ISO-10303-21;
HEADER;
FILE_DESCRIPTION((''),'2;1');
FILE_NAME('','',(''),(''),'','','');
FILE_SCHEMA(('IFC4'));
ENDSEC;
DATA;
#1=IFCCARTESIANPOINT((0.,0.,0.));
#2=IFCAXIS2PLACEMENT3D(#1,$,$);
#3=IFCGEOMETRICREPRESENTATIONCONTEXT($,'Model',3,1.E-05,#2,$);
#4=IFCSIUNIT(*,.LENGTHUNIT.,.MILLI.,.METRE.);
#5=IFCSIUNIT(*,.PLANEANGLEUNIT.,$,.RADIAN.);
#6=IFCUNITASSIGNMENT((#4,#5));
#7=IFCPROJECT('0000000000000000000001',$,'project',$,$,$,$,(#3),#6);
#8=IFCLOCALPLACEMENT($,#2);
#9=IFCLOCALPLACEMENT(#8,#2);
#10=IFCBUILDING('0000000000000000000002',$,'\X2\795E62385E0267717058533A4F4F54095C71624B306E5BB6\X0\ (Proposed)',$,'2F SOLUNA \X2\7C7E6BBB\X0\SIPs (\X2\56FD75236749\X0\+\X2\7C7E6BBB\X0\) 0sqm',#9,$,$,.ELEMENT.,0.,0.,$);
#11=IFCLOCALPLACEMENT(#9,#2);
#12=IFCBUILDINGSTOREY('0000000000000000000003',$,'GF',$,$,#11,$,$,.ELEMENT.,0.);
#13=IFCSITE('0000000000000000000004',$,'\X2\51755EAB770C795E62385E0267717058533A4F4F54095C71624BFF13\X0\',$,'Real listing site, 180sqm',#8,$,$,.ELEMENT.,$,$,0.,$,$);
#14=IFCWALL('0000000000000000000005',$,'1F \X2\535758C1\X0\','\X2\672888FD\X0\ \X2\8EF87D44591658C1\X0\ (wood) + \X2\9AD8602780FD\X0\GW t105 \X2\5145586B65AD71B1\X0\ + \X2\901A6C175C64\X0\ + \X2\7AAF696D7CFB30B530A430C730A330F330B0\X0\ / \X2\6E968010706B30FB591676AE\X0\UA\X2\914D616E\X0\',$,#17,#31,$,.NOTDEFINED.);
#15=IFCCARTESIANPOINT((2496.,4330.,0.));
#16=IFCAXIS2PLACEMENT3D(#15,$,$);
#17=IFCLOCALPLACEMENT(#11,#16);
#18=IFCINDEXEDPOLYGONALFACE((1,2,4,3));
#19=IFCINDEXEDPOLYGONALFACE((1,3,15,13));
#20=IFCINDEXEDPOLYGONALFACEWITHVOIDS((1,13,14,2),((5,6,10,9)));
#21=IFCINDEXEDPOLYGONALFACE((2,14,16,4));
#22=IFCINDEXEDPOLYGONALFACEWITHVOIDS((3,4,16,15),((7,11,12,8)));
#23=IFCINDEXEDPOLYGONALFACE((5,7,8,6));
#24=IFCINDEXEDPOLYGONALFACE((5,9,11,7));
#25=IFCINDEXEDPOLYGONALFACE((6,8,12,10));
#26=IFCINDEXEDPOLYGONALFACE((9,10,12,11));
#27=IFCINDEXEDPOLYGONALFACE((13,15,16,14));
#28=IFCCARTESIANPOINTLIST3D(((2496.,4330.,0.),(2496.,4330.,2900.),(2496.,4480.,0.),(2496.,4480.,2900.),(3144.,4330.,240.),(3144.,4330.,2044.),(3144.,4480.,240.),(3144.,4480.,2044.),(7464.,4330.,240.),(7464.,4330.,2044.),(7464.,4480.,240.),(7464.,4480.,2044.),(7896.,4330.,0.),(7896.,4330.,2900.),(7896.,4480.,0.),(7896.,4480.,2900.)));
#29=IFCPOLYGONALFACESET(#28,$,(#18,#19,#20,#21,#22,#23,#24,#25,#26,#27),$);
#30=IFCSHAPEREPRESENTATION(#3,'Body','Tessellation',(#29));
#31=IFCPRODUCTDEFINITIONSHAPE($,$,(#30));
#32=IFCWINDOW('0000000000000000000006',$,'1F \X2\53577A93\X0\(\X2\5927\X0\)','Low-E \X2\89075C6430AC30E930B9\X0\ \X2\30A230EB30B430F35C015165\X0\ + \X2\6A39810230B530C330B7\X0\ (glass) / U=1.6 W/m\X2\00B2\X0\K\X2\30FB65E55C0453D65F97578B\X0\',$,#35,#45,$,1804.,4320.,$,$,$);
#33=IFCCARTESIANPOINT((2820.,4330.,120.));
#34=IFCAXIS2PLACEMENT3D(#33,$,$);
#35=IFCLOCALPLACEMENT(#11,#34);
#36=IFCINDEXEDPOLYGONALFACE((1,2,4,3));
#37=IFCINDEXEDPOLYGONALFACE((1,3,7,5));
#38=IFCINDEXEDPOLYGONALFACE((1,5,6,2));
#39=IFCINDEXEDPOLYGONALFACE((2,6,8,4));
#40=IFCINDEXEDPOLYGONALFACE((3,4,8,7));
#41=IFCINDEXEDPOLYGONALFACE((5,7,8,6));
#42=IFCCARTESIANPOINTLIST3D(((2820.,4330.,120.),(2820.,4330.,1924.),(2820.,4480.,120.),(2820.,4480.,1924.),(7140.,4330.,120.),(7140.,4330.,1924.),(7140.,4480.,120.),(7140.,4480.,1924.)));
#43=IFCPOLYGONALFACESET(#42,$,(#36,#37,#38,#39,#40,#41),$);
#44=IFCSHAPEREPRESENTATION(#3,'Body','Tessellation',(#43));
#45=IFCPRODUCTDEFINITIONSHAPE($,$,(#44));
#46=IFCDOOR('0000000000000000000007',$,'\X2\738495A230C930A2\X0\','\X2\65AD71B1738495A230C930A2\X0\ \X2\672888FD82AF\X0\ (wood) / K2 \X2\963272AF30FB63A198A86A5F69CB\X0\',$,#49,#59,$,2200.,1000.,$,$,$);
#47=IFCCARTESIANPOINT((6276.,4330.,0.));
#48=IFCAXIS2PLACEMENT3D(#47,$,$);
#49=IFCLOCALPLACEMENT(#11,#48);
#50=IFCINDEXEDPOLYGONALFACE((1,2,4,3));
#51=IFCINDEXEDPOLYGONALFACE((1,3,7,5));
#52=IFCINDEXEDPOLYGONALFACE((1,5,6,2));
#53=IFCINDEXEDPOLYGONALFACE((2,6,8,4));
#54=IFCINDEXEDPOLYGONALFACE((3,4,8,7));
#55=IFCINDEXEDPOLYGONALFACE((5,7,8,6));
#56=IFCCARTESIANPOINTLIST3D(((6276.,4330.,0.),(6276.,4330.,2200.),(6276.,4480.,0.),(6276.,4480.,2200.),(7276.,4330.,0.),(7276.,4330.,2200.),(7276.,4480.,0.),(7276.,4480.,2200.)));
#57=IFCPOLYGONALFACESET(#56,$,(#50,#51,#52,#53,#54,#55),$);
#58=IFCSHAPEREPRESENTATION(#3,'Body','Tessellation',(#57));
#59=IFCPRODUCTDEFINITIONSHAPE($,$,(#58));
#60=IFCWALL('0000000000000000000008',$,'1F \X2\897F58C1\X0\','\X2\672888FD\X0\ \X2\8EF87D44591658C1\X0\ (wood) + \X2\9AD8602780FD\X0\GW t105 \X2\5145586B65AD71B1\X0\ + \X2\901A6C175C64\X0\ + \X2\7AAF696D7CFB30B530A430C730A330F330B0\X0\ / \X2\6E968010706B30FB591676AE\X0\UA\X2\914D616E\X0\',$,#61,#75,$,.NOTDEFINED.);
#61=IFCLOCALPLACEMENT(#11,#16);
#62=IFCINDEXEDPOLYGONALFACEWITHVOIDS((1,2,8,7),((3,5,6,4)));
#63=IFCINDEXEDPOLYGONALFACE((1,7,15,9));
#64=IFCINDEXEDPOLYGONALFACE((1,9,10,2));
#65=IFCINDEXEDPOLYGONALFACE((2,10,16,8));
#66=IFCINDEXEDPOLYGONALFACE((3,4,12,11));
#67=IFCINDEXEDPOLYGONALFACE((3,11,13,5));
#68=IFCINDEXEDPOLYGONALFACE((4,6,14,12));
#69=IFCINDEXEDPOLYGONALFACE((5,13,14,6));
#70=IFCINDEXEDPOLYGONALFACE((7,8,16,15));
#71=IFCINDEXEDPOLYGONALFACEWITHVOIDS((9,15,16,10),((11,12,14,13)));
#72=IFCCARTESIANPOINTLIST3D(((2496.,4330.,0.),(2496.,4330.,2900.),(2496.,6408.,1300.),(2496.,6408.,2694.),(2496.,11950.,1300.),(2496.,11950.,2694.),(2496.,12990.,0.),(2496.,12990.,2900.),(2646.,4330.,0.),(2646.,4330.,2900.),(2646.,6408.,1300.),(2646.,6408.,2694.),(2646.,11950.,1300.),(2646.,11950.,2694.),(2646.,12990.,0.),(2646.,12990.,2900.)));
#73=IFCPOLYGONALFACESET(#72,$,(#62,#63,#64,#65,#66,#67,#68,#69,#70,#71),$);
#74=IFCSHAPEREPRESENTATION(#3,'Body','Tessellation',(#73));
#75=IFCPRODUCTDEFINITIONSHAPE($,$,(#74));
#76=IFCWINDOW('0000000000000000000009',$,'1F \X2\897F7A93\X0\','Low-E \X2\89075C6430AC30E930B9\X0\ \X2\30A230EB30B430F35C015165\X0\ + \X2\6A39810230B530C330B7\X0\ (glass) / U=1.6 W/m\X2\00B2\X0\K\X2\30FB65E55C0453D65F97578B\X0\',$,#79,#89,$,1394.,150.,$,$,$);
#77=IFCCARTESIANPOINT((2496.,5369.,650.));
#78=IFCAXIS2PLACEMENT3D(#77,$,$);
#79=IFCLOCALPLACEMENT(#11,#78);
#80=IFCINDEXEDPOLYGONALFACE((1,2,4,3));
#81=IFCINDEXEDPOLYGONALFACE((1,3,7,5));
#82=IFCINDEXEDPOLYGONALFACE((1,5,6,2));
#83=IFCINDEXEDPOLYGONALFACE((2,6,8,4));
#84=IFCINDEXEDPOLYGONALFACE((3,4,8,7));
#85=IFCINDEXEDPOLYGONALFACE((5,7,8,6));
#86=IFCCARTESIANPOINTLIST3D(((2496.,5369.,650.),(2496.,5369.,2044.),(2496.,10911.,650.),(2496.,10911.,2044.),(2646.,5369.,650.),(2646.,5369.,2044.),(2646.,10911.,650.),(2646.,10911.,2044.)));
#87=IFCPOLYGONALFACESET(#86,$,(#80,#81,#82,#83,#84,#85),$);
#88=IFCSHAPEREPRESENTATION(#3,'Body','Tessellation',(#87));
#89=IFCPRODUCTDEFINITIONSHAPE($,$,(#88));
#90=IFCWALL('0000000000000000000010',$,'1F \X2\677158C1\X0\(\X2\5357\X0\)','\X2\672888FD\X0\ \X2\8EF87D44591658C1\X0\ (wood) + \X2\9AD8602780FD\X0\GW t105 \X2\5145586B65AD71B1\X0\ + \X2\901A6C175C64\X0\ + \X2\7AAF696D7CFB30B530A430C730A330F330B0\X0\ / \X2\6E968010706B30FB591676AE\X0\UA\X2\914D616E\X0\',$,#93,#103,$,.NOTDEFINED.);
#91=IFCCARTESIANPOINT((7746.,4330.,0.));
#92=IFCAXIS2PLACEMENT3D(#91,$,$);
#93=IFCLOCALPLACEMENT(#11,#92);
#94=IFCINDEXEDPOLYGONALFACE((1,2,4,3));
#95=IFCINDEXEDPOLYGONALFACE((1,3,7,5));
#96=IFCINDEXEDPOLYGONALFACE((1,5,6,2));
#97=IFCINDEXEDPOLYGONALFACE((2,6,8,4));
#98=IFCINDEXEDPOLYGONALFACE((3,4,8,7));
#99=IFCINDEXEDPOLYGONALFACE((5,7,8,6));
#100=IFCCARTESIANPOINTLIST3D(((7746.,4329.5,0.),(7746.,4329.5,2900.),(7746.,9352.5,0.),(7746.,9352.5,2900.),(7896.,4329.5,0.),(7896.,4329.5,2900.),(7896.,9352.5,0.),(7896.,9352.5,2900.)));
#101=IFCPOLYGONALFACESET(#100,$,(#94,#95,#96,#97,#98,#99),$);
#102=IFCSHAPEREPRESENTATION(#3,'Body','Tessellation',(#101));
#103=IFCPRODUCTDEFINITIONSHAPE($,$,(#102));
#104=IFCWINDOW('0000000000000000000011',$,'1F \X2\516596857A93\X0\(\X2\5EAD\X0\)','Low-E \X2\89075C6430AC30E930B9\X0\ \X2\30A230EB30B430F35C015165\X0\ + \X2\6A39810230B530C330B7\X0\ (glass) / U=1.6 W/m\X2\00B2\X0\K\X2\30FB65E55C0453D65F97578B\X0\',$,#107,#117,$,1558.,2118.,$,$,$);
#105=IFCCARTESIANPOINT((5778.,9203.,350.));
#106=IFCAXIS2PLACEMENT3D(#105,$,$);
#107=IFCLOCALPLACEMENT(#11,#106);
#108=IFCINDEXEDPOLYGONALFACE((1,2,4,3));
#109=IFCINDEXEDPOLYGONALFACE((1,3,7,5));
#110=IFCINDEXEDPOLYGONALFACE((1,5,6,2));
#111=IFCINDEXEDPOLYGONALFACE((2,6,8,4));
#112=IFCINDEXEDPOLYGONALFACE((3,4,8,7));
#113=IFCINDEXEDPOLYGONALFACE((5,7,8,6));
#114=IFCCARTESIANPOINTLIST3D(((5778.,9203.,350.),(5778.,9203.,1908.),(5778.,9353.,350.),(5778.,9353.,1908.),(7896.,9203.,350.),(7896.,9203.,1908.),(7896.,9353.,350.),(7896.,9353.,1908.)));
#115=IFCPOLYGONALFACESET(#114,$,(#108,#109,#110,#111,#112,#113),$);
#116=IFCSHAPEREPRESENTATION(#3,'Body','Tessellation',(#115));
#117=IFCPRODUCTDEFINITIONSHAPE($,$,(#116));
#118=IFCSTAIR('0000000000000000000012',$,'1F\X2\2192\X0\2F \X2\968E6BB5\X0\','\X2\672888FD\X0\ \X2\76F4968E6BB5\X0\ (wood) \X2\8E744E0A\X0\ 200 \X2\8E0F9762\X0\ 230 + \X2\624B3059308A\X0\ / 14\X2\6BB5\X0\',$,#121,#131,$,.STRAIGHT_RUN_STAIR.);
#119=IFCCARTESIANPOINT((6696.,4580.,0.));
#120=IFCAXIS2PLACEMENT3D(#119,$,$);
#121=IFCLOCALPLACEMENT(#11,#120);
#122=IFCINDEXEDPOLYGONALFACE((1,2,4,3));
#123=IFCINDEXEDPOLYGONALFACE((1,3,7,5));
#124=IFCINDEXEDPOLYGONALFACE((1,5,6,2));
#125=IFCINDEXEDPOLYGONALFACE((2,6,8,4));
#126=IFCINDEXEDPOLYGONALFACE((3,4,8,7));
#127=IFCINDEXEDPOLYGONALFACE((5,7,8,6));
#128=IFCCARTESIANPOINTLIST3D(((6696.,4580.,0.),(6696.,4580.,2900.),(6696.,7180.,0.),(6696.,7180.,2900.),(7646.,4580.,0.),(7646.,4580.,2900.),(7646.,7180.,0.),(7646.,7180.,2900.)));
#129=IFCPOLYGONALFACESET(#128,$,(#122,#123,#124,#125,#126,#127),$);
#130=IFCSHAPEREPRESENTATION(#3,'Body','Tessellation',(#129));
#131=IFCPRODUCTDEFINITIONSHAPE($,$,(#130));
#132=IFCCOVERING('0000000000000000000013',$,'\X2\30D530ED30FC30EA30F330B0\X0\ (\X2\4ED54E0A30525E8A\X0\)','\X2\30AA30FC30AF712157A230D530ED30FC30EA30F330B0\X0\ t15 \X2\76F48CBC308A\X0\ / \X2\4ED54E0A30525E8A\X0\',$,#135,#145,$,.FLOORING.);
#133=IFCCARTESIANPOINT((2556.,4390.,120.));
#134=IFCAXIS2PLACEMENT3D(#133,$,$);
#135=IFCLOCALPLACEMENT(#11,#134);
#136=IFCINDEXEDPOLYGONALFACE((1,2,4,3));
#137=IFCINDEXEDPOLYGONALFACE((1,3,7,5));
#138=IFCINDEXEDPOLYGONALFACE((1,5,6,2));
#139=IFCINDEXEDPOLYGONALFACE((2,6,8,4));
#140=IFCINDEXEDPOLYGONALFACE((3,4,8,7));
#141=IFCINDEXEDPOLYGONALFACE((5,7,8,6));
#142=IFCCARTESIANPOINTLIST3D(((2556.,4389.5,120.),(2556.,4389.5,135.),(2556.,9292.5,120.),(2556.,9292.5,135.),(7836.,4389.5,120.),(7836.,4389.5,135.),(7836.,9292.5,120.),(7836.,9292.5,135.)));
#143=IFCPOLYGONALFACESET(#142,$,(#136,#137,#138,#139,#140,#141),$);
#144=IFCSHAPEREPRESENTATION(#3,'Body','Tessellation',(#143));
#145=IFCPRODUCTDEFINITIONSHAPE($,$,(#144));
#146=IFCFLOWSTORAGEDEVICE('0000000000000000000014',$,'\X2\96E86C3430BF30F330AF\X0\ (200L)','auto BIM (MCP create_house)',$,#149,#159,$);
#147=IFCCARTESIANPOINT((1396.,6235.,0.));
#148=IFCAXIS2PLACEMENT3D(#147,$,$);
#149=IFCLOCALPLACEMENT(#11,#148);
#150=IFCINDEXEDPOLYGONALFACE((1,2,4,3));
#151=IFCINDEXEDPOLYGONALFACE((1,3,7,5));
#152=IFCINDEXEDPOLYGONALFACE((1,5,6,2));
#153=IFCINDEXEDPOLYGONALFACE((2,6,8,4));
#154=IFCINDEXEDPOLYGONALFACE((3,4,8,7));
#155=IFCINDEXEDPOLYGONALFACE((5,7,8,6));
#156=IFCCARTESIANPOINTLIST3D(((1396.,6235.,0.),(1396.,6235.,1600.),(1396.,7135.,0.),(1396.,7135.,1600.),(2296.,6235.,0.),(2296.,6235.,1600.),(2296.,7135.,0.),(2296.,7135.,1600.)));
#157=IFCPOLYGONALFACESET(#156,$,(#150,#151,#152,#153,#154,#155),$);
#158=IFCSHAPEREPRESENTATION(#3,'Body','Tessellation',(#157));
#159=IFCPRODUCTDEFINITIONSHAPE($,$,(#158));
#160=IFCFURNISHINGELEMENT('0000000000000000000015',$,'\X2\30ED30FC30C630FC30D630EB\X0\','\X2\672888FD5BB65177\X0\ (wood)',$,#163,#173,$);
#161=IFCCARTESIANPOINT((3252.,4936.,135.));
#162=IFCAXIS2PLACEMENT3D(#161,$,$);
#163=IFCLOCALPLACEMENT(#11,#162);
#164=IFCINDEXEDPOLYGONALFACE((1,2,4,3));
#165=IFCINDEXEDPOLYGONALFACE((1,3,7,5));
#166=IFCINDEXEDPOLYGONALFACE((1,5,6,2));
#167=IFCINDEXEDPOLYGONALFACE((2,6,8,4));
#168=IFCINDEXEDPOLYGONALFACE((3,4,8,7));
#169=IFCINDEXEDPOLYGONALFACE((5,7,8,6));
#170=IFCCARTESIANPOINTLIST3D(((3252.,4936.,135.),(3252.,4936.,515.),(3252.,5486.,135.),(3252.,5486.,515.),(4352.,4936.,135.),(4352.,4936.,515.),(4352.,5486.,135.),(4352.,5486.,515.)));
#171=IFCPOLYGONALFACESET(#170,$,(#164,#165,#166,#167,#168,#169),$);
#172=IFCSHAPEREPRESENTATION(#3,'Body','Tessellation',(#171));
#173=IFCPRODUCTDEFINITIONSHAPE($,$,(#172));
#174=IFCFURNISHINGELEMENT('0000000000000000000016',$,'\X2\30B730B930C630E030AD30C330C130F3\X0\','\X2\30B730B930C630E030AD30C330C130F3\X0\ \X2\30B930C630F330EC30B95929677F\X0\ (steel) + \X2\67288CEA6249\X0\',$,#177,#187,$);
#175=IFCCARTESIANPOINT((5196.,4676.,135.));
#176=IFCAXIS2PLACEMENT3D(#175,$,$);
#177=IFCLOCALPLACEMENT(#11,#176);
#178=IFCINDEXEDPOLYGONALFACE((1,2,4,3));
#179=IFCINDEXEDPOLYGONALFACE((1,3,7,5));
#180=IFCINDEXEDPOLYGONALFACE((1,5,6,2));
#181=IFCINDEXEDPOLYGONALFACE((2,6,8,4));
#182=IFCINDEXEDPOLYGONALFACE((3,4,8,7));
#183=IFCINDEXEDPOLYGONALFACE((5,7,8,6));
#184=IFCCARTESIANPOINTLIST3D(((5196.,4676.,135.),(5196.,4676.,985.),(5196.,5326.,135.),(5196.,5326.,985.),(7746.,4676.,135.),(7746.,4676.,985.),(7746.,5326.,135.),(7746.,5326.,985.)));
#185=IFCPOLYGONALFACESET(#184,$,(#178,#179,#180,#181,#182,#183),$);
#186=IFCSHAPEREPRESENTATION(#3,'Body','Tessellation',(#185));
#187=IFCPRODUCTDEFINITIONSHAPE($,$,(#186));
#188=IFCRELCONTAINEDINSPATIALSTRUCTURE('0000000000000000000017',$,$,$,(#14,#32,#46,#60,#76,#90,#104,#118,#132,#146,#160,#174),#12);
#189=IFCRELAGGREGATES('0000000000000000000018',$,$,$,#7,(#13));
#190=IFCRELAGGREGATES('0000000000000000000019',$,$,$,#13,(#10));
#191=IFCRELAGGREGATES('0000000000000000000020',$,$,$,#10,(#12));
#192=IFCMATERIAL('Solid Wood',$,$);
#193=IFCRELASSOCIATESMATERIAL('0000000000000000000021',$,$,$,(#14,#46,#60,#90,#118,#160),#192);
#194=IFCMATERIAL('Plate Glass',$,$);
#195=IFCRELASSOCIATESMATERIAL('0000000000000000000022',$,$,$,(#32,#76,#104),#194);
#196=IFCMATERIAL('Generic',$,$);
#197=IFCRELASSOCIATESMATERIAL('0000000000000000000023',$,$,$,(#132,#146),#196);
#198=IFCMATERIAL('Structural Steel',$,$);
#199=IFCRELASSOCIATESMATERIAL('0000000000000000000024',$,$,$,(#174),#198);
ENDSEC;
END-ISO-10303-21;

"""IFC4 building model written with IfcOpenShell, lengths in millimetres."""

from ifc_helpers import new_model, si_unit, frame, frame_2d, origin, place, context, project, spatial, rectangle, extrude, material, element, fill, save


model = new_model("IFC4")

# Units and contexts
model_context = context("Model", 3, precision=1e-05, world=origin())
ifc_project = project(units=[si_unit("LENGTHUNIT", "METRE", prefix="MILLI"), si_unit("PLANEANGLEUNIT", "RADIAN")], contexts=[model_context])

# Site, building, storey
site_placement = place(None, origin())
site = spatial("IfcSite", under=ifc_project, at=site_placement, Name="兵庫県神戸市東灘区住吉山手３", ObjectType="Real listing site, 180sqm", CompositionType="ELEMENT", RefElevation=0.0)
building_placement = place(site_placement, origin())
building = spatial("IfcBuilding", under=site, at=building_placement, Name="神戸市東灘区住吉山手の家 (Proposed)", ObjectType="2F SOLUNA 籾殻SIPs (国産杉+籾殻) 0sqm", CompositionType="ELEMENT", ElevationOfRefHeight=0.0, ElevationOfTerrain=0.0)
storey_placement = place(building_placement, origin())
storey = spatial("IfcBuildingStorey", under=building, at=storey_placement, Name="GF", CompositionType="ELEMENT", Elevation=0.0)

# Shared definitions
ifc_material_1 = material(Name="Solid Wood")

# Wall, openings, window, door
wall_1_placement = place(storey_placement, frame((2496.0, 4330.0, 0.0)))
wall_1 = element("IfcWall", 1, at=wall_1_placement, inside=storey, material=ifc_material_1, Name="1F 南壁", Description="木製 軸組外壁 (wood) + 高性能GW t105 充填断熱 + 通気層 + 窯業系サイディング / 準耐火・外皮UA配慮", PredefinedType="NOTDEFINED", context=model_context, shape_type="SweptSolid", body=[
    extrude(rectangle(XDim=5400.0, YDim=150.0, at=frame_2d((2700.0, 75.0))), frame((2496.0, 4330.0, 0.0)), (0.0, 0.0, 1.0), 2900.0),
])
opening_1_placement = place(storey_placement, frame((2820.0, 4330.0, 120.0)))
opening_1 = element("IfcOpeningElement", 2, at=opening_1_placement, cuts=wall_1, PredefinedType="NOTDEFINED", context=model_context, shape_type="SweptSolid", body=[
    extrude(rectangle(XDim=4320.0, YDim=150.0, at=frame_2d((2160.0, 75.0))), frame((2820.0, 4330.0, 120.0)), (0.0, 0.0, 1.0), 1804.0),
])
opening_2_placement = place(storey_placement, frame((6276.0, 4330.0, 0.0)))
opening_2 = element("IfcOpeningElement", 3, at=opening_2_placement, cuts=wall_1, PredefinedType="NOTDEFINED", context=model_context, shape_type="SweptSolid", body=[
    extrude(rectangle(XDim=1000.0, YDim=150.0, at=frame_2d((500.0, 75.0))), frame((6276.0, 4330.0, 0.0)), (0.0, 0.0, 1.0), 2200.0),
])
ifc_material_2 = material(Name="Plate Glass")
window_1_placement = place(storey_placement, frame((2820.0, 4330.0, 120.0)))
window_1 = element("IfcWindow", 4, at=window_1_placement, inside=storey, material=ifc_material_2, Name="1F 南窓(大)", Description="Low-E 複層ガラス アルゴン封入 + 樹脂サッシ (glass) / U=1.6 W/m²K・日射取得型", OverallHeight=1804.0, OverallWidth=4320.0, context=model_context, shape_type="SweptSolid", body=[
    extrude(rectangle(XDim=4320.0, YDim=150.0, at=frame_2d((2160.0, 75.0))), frame((2820.0, 4330.0, 120.0)), (0.0, 0.0, 1.0), 1804.0),
])
fill(opening_1, window_1)
door_1_placement = place(storey_placement, frame((6276.0, 4330.0, 0.0)))
door_1 = element("IfcDoor", 5, at=door_1_placement, inside=storey, material=ifc_material_1, Name="玄関ドア", Description="断熱玄関ドア 木製芯 (wood) / K2 防犯・採風機構", OverallHeight=2200.0, OverallWidth=1000.0, context=model_context, shape_type="SweptSolid", body=[
    extrude(rectangle(XDim=1000.0, YDim=150.0, at=frame_2d((500.0, 75.0))), frame((6276.0, 4330.0, 0.0)), (0.0, 0.0, 1.0), 2200.0),
])
fill(opening_2, door_1)

# Walls, openings, windows
wall_2_placement = place(storey_placement, frame((2496.0, 4330.0, 0.0)))
wall_2 = element("IfcWall", 6, at=wall_2_placement, inside=storey, material=ifc_material_1, Name="1F 西壁", Description="木製 軸組外壁 (wood) + 高性能GW t105 充填断熱 + 通気層 + 窯業系サイディング / 準耐火・外皮UA配慮", PredefinedType="NOTDEFINED", context=model_context, shape_type="SweptSolid", body=[
    extrude(rectangle(XDim=150.0, YDim=8660.0, at=frame_2d((75.0, 4330.0))), frame((2496.0, 4330.0, 0.0)), (0.0, 0.0, 1.0), 2900.0),
])
opening_3_placement = place(storey_placement, frame((2496.0, 5369.0, 650.0)))
opening_3 = element("IfcOpeningElement", 7, at=opening_3_placement, cuts=wall_2, PredefinedType="NOTDEFINED", context=model_context, shape_type="SweptSolid", body=[
    extrude(rectangle(XDim=150.0, YDim=5542.0, at=frame_2d((75.0, 2771.0))), frame((2496.0, 5369.0, 650.0)), (0.0, 0.0, 1.0), 1394.0),
])
window_2_placement = place(storey_placement, frame((2496.0, 5369.0, 650.0)))
window_2 = element("IfcWindow", 8, at=window_2_placement, inside=storey, material=ifc_material_2, Name="1F 西窓", Description="Low-E 複層ガラス アルゴン封入 + 樹脂サッシ (glass) / U=1.6 W/m²K・日射取得型", OverallHeight=1394.0, OverallWidth=150.0, context=model_context, shape_type="SweptSolid", body=[
    extrude(rectangle(XDim=150.0, YDim=5542.0, at=frame_2d((75.0, 2771.0))), frame((2496.0, 5369.0, 650.0)), (0.0, 0.0, 1.0), 1394.0),
])
fill(opening_3, window_2)
wall_3_placement = place(storey_placement, frame((7746.0, 4330.0, 0.0)))
wall_3 = element("IfcWall", 9, at=wall_3_placement, inside=storey, material=ifc_material_1, Name="1F 東壁(南)", Description="木製 軸組外壁 (wood) + 高性能GW t105 充填断熱 + 通気層 + 窯業系サイディング / 準耐火・外皮UA配慮", PredefinedType="NOTDEFINED", context=model_context, shape_type="SweptSolid", body=[
    extrude(rectangle(XDim=150.0, YDim=5023.0, at=frame_2d((75.0, 2511.0))), frame((7746.0, 4330.0, 0.0)), (0.0, 0.0, 1.0), 2900.0),
])
opening_4_placement = place(storey_placement, frame((5778.0, 9203.0, 350.0)))
opening_4 = element("IfcOpeningElement", 10, at=opening_4_placement, cuts=wall_3, PredefinedType="NOTDEFINED", context=model_context, shape_type="SweptSolid", body=[
    extrude(rectangle(XDim=2118.0, YDim=150.0, at=frame_2d((1059.0, 75.0))), frame((5778.0, 9203.0, 350.0)), (0.0, 0.0, 1.0), 1558.0),
])
window_3_placement = place(storey_placement, frame((5778.0, 9203.0, 350.0)))
window_3 = element("IfcWindow", 11, at=window_3_placement, inside=storey, material=ifc_material_2, Name="1F 入隅窓(庭)", Description="Low-E 複層ガラス アルゴン封入 + 樹脂サッシ (glass) / U=1.6 W/m²K・日射取得型", OverallHeight=1558.0, OverallWidth=2118.0, context=model_context, shape_type="SweptSolid", body=[
    extrude(rectangle(XDim=2118.0, YDim=150.0, at=frame_2d((1059.0, 75.0))), frame((5778.0, 9203.0, 350.0)), (0.0, 0.0, 1.0), 1558.0),
])
fill(opening_4, window_3)

# Stair
stair_placement = place(storey_placement, frame((6696.0, 4580.0, 0.0)))
element("IfcStair", 12, at=stair_placement, inside=storey, material=ifc_material_1, Name="1F→2F 階段", Description="木製 直階段 (wood) 蹴上 200 踏面 230 + 手すり / 14段", PredefinedType="STRAIGHT_RUN_STAIR", context=model_context, shape_type="SweptSolid", body=[
    extrude(rectangle(XDim=950.0, YDim=2600.0, at=frame_2d((475.0, 1300.0))), frame((6696.0, 4580.0, 0.0)), (0.0, 0.0, 1.0), 2900.0),
])

# Covering
ifc_material_3 = material(Name="Generic")
covering_placement = place(storey_placement, frame((2556.0, 4390.0, 120.0)))
element("IfcCovering", 13, at=covering_placement, inside=storey, material=ifc_material_3, Name="フローリング (仕上げ床)", Description="オーク無垢フローリング t15 直貼り / 仕上げ床", PredefinedType="FLOORING", context=model_context, shape_type="SweptSolid", body=[
    extrude(rectangle(XDim=5280.0, YDim=4903.0, at=frame_2d((2640.0, 2451.0))), frame((2556.0, 4390.0, 120.0)), (0.0, 0.0, 1.0), 15.0),
])

# Flow storage device
flow_storage_device_placement = place(storey_placement, frame((1396.0, 6235.0, 0.0)))
element("IfcFlowStorageDevice", 14, at=flow_storage_device_placement, inside=storey, material=ifc_material_3, Name="雨水タンク (200L)", Description="auto BIM (MCP create_house)", context=model_context, shape_type="SweptSolid", body=[
    extrude(rectangle(XDim=900.0, YDim=900.0, at=frame_2d((450.0, 450.0))), frame((1396.0, 6235.0, 0.0)), (0.0, 0.0, 1.0), 1600.0),
])

# Furnishing elements
furnishing_1_placement = place(storey_placement, frame((3252.0, 4936.0, 135.0)))
element("IfcFurnishingElement", 15, at=furnishing_1_placement, inside=storey, material=ifc_material_1, Name="ローテーブル", Description="木製家具 (wood)", context=model_context, shape_type="SweptSolid", body=[
    extrude(rectangle(XDim=1100.0, YDim=550.0, at=frame_2d((550.0, 275.0))), frame((3252.0, 4936.0, 135.0)), (0.0, 0.0, 1.0), 380.0),
])
ifc_material_4 = material(Name="Structural Steel")
furnishing_2_placement = place(storey_placement, frame((5196.0, 4676.0, 135.0)))
element("IfcFurnishingElement", 16, at=furnishing_2_placement, inside=storey, material=ifc_material_4, Name="システムキッチン", Description="システムキッチン ステンレス天板 (steel) + 木質扉", context=model_context, shape_type="SweptSolid", body=[
    extrude(rectangle(XDim=2550.0, YDim=650.0, at=frame_2d((1275.0, 325.0))), frame((5196.0, 4676.0, 135.0)), (0.0, 0.0, 1.0), 850.0),
])

save(model, "model.ifc")
